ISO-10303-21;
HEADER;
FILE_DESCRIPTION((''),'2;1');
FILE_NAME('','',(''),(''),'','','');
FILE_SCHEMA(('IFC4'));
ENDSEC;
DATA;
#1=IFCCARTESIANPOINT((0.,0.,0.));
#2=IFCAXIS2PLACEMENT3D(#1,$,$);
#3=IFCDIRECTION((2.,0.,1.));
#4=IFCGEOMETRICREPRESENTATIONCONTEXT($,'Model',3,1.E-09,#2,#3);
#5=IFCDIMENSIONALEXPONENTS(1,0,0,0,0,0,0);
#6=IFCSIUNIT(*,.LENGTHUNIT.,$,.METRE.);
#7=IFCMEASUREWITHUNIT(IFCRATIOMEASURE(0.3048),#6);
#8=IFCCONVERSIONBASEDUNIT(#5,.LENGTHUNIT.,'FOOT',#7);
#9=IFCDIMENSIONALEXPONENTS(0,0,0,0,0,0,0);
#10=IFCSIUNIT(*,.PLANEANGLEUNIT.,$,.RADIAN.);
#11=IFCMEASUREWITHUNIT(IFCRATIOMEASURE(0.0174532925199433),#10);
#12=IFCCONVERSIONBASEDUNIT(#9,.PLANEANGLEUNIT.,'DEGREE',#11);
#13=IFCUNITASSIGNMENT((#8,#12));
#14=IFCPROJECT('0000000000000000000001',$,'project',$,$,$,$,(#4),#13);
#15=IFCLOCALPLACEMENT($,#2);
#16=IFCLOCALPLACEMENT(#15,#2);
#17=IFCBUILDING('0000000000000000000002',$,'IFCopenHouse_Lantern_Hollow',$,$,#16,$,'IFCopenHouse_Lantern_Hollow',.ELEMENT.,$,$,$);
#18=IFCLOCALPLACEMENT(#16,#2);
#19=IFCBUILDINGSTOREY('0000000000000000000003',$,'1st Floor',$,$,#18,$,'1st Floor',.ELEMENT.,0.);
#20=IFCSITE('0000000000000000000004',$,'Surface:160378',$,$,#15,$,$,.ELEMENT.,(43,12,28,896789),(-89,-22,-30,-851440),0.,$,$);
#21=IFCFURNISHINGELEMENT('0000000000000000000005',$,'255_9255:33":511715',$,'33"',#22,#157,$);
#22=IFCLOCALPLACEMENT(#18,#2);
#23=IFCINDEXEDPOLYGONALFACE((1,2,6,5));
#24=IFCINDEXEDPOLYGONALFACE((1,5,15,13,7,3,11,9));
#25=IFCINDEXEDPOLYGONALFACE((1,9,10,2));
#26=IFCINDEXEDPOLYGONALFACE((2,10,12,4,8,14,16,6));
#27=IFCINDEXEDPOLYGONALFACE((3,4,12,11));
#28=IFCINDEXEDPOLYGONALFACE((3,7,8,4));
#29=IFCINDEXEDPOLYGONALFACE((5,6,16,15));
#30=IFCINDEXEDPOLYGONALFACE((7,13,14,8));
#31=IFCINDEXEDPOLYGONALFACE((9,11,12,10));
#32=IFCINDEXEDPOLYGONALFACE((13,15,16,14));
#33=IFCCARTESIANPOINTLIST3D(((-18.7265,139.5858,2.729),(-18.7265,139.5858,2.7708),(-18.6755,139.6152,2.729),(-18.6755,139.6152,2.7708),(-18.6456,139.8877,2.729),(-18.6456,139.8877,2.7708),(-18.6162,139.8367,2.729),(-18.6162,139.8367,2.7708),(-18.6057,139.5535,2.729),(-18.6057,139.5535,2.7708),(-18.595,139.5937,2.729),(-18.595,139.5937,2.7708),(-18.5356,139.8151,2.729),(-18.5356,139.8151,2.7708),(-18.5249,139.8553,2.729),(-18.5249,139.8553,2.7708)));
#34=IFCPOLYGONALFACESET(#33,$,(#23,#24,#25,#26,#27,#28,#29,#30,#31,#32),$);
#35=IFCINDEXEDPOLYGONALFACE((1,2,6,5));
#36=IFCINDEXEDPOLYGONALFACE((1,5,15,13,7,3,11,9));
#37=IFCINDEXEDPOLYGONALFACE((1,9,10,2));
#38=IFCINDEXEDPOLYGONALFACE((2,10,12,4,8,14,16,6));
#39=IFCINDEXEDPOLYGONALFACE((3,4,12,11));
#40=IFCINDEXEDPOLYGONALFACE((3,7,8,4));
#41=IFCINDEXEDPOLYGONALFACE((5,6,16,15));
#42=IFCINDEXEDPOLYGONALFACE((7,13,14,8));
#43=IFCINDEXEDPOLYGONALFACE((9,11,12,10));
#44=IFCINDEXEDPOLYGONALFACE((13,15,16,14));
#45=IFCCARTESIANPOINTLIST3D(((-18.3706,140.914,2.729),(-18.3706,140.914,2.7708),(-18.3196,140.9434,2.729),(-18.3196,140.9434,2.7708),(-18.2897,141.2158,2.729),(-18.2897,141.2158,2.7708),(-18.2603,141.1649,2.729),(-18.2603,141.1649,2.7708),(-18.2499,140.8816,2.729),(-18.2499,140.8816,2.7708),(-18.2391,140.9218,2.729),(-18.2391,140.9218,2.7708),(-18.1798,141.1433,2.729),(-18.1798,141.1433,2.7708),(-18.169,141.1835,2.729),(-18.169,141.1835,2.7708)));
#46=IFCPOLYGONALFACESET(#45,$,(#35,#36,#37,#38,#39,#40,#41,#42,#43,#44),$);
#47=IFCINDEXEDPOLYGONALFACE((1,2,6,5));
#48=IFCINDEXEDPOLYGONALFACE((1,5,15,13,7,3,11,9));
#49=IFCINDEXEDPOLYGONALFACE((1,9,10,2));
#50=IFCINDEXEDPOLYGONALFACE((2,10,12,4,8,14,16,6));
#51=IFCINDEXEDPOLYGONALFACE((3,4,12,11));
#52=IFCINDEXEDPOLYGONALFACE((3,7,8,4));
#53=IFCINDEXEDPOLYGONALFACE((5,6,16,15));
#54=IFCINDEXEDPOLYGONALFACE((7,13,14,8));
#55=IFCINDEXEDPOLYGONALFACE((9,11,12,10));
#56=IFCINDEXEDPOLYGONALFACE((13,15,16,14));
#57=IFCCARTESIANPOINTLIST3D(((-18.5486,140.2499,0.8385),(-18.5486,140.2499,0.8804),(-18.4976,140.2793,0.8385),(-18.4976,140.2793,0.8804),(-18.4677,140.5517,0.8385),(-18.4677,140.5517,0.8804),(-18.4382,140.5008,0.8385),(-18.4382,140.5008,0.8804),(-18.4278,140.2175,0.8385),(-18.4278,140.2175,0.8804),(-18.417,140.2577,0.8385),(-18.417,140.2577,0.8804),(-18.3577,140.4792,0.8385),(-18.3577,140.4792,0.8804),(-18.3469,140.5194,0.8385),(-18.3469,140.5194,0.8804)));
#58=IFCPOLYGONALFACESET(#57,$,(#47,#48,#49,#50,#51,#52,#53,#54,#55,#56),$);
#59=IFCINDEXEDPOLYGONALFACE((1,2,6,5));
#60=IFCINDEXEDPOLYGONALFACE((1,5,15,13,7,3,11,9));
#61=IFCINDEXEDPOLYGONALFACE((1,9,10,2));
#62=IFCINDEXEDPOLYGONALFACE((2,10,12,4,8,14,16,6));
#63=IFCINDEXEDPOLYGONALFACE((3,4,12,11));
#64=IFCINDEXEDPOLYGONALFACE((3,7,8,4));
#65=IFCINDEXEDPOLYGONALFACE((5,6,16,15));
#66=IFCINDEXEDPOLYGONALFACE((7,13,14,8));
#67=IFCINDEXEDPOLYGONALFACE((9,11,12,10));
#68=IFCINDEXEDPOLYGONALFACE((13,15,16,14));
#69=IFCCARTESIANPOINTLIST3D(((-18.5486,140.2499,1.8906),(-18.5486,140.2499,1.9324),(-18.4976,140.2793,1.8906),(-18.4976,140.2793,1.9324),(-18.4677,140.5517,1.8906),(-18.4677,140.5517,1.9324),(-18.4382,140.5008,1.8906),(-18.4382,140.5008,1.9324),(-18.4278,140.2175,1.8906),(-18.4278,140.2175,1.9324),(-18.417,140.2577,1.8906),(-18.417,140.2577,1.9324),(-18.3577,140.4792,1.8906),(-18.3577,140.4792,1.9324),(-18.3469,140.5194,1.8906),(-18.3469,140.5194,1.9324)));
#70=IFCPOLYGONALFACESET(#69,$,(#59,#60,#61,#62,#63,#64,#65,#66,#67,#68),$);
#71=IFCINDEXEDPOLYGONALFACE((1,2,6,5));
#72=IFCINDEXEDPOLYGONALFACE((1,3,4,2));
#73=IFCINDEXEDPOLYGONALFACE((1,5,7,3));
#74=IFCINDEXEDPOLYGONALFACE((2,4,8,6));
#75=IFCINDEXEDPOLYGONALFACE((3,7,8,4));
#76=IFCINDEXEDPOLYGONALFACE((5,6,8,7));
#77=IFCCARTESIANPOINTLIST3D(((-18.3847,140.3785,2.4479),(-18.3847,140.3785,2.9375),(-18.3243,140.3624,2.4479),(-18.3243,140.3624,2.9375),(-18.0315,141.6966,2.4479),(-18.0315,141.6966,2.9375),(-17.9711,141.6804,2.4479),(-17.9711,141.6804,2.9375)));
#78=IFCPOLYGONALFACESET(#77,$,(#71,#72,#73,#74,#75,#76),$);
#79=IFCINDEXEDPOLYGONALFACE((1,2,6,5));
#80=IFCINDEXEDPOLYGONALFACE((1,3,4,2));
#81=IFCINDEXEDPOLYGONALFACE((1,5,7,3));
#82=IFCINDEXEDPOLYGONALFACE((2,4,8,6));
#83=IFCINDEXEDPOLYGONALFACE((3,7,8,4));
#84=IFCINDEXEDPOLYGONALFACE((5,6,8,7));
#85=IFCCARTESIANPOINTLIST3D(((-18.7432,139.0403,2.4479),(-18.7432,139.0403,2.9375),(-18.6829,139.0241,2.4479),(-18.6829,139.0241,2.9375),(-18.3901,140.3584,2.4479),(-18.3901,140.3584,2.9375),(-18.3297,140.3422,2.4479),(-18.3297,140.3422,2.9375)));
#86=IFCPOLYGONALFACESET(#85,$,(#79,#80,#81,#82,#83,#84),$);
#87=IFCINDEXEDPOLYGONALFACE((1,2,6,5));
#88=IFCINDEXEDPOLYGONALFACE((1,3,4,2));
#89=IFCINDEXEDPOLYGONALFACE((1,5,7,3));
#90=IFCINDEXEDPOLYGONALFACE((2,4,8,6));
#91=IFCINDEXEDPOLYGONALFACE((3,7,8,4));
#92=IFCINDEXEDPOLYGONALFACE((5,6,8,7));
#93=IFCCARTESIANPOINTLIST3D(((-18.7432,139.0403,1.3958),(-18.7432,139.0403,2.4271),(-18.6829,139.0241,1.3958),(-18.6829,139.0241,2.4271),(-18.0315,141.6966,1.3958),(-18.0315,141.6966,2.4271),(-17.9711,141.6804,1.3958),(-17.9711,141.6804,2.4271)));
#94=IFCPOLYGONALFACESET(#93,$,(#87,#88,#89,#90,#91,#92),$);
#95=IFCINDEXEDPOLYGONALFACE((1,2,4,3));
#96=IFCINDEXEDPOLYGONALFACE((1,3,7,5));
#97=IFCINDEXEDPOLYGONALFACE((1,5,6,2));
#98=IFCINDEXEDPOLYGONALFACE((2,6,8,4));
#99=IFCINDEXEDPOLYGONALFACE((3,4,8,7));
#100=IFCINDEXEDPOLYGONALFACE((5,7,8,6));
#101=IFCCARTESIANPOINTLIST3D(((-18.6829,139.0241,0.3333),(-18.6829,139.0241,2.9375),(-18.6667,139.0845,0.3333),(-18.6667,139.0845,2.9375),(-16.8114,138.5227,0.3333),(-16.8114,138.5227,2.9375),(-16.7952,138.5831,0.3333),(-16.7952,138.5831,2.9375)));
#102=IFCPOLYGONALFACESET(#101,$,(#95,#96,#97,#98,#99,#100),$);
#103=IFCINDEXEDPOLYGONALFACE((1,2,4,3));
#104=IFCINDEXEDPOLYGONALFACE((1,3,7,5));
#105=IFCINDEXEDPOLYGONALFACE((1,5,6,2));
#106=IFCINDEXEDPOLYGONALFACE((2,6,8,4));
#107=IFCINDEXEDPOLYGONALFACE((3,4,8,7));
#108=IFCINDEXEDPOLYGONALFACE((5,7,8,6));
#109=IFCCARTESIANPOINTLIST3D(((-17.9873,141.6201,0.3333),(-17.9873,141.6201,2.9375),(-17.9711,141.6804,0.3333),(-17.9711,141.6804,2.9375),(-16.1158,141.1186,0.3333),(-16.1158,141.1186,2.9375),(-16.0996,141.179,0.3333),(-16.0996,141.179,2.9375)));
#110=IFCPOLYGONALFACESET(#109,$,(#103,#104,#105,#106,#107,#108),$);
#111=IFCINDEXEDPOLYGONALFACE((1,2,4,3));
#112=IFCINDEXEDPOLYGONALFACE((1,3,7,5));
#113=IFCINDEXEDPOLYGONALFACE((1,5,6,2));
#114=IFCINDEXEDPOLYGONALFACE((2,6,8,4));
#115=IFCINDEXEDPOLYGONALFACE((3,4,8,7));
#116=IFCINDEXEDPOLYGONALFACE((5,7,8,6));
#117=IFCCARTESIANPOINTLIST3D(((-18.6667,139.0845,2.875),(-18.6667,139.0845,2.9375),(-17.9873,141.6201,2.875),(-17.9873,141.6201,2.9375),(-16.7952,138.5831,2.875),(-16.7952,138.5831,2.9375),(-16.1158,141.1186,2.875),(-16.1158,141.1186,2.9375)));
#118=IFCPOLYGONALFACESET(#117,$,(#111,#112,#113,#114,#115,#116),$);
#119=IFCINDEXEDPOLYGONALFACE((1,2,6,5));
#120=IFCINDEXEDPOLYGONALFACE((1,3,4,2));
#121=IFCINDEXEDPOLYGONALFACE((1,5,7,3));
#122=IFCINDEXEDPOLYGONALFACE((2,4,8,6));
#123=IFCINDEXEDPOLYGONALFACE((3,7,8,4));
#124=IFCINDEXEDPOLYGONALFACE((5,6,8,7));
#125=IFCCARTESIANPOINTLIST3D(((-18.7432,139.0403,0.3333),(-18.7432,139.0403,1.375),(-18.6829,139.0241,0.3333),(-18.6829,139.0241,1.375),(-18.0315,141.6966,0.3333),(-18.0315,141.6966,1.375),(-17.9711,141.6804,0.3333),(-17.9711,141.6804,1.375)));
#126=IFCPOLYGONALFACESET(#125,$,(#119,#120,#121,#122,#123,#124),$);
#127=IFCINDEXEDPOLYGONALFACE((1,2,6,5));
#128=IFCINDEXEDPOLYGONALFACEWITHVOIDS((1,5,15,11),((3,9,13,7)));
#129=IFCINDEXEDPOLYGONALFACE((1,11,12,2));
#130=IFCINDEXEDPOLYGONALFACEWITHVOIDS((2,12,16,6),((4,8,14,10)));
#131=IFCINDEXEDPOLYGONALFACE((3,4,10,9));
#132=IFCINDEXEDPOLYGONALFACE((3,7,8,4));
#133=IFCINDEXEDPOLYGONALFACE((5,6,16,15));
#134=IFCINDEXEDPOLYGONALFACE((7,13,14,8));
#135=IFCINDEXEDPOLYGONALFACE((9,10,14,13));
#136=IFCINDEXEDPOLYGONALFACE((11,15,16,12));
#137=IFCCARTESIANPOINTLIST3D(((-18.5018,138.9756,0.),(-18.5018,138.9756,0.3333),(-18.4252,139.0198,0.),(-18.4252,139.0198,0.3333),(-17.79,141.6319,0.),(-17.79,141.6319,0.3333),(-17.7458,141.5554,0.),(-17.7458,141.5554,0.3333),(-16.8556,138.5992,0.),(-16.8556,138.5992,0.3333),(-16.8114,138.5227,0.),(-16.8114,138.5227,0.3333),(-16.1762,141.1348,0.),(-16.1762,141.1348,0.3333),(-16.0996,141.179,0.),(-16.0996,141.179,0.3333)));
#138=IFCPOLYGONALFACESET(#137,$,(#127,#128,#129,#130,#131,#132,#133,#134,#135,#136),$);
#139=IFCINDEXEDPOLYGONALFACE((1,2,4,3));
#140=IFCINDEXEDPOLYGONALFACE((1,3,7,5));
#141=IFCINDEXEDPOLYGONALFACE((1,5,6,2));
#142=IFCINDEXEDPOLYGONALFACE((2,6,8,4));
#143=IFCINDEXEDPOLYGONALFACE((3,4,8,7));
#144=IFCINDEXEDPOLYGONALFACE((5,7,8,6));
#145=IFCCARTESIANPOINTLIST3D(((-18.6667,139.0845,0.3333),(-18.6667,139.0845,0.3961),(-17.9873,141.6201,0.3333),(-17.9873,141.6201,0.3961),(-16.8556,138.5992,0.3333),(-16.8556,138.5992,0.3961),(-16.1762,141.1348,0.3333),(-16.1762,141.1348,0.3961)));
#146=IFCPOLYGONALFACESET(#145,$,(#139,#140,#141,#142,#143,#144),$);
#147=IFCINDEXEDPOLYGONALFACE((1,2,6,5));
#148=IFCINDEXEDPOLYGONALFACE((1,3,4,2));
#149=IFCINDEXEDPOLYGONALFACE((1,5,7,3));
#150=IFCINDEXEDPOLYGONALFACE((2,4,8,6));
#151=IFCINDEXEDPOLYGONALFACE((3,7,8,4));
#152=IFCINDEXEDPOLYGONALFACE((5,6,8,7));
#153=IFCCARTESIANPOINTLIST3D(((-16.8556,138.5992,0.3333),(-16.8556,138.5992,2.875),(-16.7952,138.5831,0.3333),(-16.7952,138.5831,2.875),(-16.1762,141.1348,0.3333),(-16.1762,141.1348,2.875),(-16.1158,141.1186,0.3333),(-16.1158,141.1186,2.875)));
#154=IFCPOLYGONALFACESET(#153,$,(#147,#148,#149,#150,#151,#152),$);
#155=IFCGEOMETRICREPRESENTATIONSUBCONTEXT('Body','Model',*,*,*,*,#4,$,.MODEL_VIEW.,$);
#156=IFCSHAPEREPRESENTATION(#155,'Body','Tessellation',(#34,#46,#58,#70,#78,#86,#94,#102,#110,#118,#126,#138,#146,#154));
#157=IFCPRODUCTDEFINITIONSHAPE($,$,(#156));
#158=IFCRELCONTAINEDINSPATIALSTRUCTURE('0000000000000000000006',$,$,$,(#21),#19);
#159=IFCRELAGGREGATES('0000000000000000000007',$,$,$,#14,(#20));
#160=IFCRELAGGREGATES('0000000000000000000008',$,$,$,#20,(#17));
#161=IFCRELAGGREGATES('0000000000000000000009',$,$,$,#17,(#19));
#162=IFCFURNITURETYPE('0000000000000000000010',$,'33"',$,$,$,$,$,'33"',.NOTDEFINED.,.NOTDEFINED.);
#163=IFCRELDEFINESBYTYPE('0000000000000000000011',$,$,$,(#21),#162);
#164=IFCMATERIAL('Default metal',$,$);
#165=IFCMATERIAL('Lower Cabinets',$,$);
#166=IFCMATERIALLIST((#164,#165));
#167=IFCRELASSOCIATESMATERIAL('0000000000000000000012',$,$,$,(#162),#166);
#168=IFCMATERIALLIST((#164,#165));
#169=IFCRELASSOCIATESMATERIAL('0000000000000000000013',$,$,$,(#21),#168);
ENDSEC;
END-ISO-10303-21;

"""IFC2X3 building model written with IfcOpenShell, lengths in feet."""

from ifc_helpers import new_model, entity, si_unit, converted_unit, direction, frame, frame_2d, origin, origin_2d_with_axis, place, context, subcontext, project, spatial, polyline, rectangle, outline, extrude, source, transform, mapped, material, material_list, type_object, type_shapes, element, save


model = new_model("IFC2X3")

# Units and contexts
model_context = context("Model", 3, precision=1e-09, world=origin(), true_north=direction((2.0, 0.0, 1.0)))
body_context = subcontext(model_context, "Body", "Model", "MODEL_VIEW")
ifc_project = project(units=[converted_unit("LENGTHUNIT", "FOOT", entity("IfcRatioMeasure", 0.3048), si_unit("LENGTHUNIT", "METRE"), dimensions=[1, 0, 0, 0, 0, 0, 0]), converted_unit("PLANEANGLEUNIT", "DEGREE", entity("IfcRatioMeasure", 0.0174532925199433), si_unit("PLANEANGLEUNIT", "RADIAN"), dimensions=[0, 0, 0, 0, 0, 0, 0])], contexts=[model_context])

# Site, building, storey
site_placement = place(None, origin())
site = spatial("IfcSite", under=ifc_project, at=site_placement, Name="Surface:160378", CompositionType="ELEMENT", RefLatitude=(43, 12, 28, 896789), RefLongitude=(-89, -22, -30, -851440), RefElevation=0.0)
building_placement = place(site_placement, origin())
building = spatial("IfcBuilding", under=site, at=building_placement, Name="IFCopenHouse_Lantern_Hollow", LongName="IFCopenHouse_Lantern_Hollow", CompositionType="ELEMENT")
storey_placement = place(building_placement, origin())
storey = spatial("IfcBuildingStorey", under=building, at=storey_placement, Name="1st Floor", LongName="1st Floor", CompositionType="ELEMENT", Elevation=0.0)

# Furnishing element
ifc_material_1 = material(Name="Default metal")
ifc_material_2 = material(Name="Lower Cabinets")
ifc_material_list_1 = material_list([ifc_material_1, ifc_material_2])
ifc_material_list_2 = material_list([ifc_material_1, ifc_material_2])
furniture_type_1 = type_object("IfcFurnitureType", Name="33\"", ElementType="33\"", AssemblyPlace="NOTDEFINED", material=ifc_material_list_2)
shared_shape_1 = source(origin(), body_context, "Body", "SweptSolid", [
    extrude(outline(polyline([(-0.1562, -0.0521), (-0.1146, -0.0521), (-0.1146, 0.0313), (0.1146, 0.0313), (0.1146, -0.0521), (0.1562, -0.0521), (0.1562, 0.0729), (-0.1562, 0.0729), (-0.1562, -0.0521)])), frame((-0.626, 2.0521, 2.729)), (0.0, 0.0, 1.0), 0.0418),
    extrude(outline(polyline([(-0.1562, -0.0521), (-0.1146, -0.0521), (-0.1146, 0.0313), (0.1146, 0.0313), (0.1146, -0.0521), (0.1562, -0.0521), (0.1562, 0.0729), (-0.1562, 0.0729), (-0.1562, -0.0521)])), frame((0.749, 2.0521, 2.729)), (0.0, 0.0, 1.0), 0.0418),
    extrude(outline(polyline([(-0.1562, -0.0521), (-0.1146, -0.0521), (-0.1146, 0.0313), (0.1146, 0.0313), (0.1146, -0.0521), (0.1562, -0.0521), (0.1562, 0.0729), (-0.1562, 0.0729), (-0.1562, -0.0521)])), frame((0.0615, 2.0521, 0.8385)), (0.0, 0.0, 1.0), 0.0418),
    extrude(outline(polyline([(-0.1562, -0.0521), (-0.1146, -0.0521), (-0.1146, 0.0313), (0.1146, 0.0313), (0.1146, -0.0521), (0.1562, -0.0521), (0.1562, 0.0729), (-0.1562, 0.0729), (-0.1562, -0.0521)])), frame((0.0615, 2.0521, 1.8906)), (0.0, 0.0, 1.0), 0.0418),
    extrude(rectangle(XDim=1.3646, YDim=0.0625, at=origin_2d_with_axis()), frame((0.7542, 1.9688, 2.4479), z_axis=(0.0, 0.0, 1.0), x_axis=(-1.0, 0.0, 0.0)), (0.0, 0.0, 1.0), 0.4896),
    extrude(rectangle(XDim=1.3646, YDim=0.0625, at=origin_2d_with_axis()), frame((-0.6312, 1.9688, 2.4479), z_axis=(0.0, 0.0, 1.0), x_axis=(-1.0, 0.0, 0.0)), (0.0, 0.0, 1.0), 0.4896),
    extrude(rectangle(XDim=2.75, YDim=0.0625, at=frame_2d((0.0, 0.0), x_axis=(1.0, 0.0))), frame((0.0615, 1.9688, 1.3958), z_axis=(0.0, 0.0, 1.0), x_axis=(-1.0, 0.0, 0.0)), (0.0, 0.0, 1.0), 1.0313),
    extrude(rectangle(XDim=1.9375, YDim=0.0625, at=frame_2d((0.0, 0.0), x_axis=(1.0, 0.0))), frame((-1.2823, 0.9687, 0.3333), z_axis=(0.0, 0.0, 1.0), x_axis=(0.0, -1.0, 0.0)), (0.0, 0.0, 1.0), 2.6042),
    extrude(rectangle(XDim=1.9375, YDim=0.0625, at=frame_2d((0.0, 0.0), x_axis=(1.0, 0.0))), frame((1.4052, 0.9687, 0.3333), z_axis=(0.0, 0.0, 1.0), x_axis=(0.0, -1.0, 0.0)), (0.0, 0.0, 1.0), 2.6042),
    extrude(rectangle(XDim=1.9375, YDim=2.625, at=origin_2d_with_axis()), frame((0.0615, 0.9688, 2.875), z_axis=(0.0, 0.0, 1.0), x_axis=(0.0, 1.0, 0.0)), (0.0, 0.0, 1.0), 0.0625),
    extrude(rectangle(XDim=2.75, YDim=0.0625, at=frame_2d((0.0, 0.0), x_axis=(1.0, 0.0))), frame((0.0615, 1.9688, 0.3333), z_axis=(0.0, 0.0, 1.0), x_axis=(-1.0, 0.0, 0.0)), (0.0, 0.0, 1.0), 1.0417),
    extrude(outline(polyline([(-0.875, -1.375), (0.875, -1.375), (0.875, 1.375), (-0.875, 1.375), (-0.875, -1.375)]), holes=[polyline([(-0.8125, -1.3125), (-0.8125, 1.3125), (0.8125, 1.3125), (0.8125, -1.3125), (-0.8125, -1.3125)])]), frame((0.0615, 0.875, 0.0), z_axis=(0.0, 0.0, 1.0), x_axis=(0.0, -1.0, 0.0)), (0.0, 0.0, 1.0), 0.3333),
    extrude(rectangle(XDim=1.875, YDim=2.625, at=origin_2d_with_axis()), frame((0.0615, 1.0, 0.3333), z_axis=(0.0, 0.0, 1.0), x_axis=(0.0, 1.0, 0.0)), (0.0, 0.0, 1.0), 0.0627),
    extrude(rectangle(XDim=2.625, YDim=0.0625, at=origin_2d_with_axis()), frame((0.0615, 0.0312, 0.3333), z_axis=(0.0, 0.0, 1.0), x_axis=(-1.0, 0.0, 0.0)), (0.0, 0.0, 1.0), 2.5417),
])
type_shapes(furniture_type_1, [shared_shape_1])
furnishing_1_placement = place(storey_placement, frame((-16.4714, 139.7914, 0.0), z_axis=(0.0, 0.0, 1.0), x_axis=(0.258819, 0.965926, 0.0)))
element("IfcFurnishingElement", 1, at=furnishing_1_placement, inside=storey, type_object=furniture_type_1, material=ifc_material_list_1, Name="255_9255:33\":511715", ObjectType="33\"", context=body_context, shape_type="MappedRepresentation", body=[
    mapped(shared_shape_1, transform((0.0, 0.0, 0.0), scale=1.0)),
])

save(model, "model.ifc")
